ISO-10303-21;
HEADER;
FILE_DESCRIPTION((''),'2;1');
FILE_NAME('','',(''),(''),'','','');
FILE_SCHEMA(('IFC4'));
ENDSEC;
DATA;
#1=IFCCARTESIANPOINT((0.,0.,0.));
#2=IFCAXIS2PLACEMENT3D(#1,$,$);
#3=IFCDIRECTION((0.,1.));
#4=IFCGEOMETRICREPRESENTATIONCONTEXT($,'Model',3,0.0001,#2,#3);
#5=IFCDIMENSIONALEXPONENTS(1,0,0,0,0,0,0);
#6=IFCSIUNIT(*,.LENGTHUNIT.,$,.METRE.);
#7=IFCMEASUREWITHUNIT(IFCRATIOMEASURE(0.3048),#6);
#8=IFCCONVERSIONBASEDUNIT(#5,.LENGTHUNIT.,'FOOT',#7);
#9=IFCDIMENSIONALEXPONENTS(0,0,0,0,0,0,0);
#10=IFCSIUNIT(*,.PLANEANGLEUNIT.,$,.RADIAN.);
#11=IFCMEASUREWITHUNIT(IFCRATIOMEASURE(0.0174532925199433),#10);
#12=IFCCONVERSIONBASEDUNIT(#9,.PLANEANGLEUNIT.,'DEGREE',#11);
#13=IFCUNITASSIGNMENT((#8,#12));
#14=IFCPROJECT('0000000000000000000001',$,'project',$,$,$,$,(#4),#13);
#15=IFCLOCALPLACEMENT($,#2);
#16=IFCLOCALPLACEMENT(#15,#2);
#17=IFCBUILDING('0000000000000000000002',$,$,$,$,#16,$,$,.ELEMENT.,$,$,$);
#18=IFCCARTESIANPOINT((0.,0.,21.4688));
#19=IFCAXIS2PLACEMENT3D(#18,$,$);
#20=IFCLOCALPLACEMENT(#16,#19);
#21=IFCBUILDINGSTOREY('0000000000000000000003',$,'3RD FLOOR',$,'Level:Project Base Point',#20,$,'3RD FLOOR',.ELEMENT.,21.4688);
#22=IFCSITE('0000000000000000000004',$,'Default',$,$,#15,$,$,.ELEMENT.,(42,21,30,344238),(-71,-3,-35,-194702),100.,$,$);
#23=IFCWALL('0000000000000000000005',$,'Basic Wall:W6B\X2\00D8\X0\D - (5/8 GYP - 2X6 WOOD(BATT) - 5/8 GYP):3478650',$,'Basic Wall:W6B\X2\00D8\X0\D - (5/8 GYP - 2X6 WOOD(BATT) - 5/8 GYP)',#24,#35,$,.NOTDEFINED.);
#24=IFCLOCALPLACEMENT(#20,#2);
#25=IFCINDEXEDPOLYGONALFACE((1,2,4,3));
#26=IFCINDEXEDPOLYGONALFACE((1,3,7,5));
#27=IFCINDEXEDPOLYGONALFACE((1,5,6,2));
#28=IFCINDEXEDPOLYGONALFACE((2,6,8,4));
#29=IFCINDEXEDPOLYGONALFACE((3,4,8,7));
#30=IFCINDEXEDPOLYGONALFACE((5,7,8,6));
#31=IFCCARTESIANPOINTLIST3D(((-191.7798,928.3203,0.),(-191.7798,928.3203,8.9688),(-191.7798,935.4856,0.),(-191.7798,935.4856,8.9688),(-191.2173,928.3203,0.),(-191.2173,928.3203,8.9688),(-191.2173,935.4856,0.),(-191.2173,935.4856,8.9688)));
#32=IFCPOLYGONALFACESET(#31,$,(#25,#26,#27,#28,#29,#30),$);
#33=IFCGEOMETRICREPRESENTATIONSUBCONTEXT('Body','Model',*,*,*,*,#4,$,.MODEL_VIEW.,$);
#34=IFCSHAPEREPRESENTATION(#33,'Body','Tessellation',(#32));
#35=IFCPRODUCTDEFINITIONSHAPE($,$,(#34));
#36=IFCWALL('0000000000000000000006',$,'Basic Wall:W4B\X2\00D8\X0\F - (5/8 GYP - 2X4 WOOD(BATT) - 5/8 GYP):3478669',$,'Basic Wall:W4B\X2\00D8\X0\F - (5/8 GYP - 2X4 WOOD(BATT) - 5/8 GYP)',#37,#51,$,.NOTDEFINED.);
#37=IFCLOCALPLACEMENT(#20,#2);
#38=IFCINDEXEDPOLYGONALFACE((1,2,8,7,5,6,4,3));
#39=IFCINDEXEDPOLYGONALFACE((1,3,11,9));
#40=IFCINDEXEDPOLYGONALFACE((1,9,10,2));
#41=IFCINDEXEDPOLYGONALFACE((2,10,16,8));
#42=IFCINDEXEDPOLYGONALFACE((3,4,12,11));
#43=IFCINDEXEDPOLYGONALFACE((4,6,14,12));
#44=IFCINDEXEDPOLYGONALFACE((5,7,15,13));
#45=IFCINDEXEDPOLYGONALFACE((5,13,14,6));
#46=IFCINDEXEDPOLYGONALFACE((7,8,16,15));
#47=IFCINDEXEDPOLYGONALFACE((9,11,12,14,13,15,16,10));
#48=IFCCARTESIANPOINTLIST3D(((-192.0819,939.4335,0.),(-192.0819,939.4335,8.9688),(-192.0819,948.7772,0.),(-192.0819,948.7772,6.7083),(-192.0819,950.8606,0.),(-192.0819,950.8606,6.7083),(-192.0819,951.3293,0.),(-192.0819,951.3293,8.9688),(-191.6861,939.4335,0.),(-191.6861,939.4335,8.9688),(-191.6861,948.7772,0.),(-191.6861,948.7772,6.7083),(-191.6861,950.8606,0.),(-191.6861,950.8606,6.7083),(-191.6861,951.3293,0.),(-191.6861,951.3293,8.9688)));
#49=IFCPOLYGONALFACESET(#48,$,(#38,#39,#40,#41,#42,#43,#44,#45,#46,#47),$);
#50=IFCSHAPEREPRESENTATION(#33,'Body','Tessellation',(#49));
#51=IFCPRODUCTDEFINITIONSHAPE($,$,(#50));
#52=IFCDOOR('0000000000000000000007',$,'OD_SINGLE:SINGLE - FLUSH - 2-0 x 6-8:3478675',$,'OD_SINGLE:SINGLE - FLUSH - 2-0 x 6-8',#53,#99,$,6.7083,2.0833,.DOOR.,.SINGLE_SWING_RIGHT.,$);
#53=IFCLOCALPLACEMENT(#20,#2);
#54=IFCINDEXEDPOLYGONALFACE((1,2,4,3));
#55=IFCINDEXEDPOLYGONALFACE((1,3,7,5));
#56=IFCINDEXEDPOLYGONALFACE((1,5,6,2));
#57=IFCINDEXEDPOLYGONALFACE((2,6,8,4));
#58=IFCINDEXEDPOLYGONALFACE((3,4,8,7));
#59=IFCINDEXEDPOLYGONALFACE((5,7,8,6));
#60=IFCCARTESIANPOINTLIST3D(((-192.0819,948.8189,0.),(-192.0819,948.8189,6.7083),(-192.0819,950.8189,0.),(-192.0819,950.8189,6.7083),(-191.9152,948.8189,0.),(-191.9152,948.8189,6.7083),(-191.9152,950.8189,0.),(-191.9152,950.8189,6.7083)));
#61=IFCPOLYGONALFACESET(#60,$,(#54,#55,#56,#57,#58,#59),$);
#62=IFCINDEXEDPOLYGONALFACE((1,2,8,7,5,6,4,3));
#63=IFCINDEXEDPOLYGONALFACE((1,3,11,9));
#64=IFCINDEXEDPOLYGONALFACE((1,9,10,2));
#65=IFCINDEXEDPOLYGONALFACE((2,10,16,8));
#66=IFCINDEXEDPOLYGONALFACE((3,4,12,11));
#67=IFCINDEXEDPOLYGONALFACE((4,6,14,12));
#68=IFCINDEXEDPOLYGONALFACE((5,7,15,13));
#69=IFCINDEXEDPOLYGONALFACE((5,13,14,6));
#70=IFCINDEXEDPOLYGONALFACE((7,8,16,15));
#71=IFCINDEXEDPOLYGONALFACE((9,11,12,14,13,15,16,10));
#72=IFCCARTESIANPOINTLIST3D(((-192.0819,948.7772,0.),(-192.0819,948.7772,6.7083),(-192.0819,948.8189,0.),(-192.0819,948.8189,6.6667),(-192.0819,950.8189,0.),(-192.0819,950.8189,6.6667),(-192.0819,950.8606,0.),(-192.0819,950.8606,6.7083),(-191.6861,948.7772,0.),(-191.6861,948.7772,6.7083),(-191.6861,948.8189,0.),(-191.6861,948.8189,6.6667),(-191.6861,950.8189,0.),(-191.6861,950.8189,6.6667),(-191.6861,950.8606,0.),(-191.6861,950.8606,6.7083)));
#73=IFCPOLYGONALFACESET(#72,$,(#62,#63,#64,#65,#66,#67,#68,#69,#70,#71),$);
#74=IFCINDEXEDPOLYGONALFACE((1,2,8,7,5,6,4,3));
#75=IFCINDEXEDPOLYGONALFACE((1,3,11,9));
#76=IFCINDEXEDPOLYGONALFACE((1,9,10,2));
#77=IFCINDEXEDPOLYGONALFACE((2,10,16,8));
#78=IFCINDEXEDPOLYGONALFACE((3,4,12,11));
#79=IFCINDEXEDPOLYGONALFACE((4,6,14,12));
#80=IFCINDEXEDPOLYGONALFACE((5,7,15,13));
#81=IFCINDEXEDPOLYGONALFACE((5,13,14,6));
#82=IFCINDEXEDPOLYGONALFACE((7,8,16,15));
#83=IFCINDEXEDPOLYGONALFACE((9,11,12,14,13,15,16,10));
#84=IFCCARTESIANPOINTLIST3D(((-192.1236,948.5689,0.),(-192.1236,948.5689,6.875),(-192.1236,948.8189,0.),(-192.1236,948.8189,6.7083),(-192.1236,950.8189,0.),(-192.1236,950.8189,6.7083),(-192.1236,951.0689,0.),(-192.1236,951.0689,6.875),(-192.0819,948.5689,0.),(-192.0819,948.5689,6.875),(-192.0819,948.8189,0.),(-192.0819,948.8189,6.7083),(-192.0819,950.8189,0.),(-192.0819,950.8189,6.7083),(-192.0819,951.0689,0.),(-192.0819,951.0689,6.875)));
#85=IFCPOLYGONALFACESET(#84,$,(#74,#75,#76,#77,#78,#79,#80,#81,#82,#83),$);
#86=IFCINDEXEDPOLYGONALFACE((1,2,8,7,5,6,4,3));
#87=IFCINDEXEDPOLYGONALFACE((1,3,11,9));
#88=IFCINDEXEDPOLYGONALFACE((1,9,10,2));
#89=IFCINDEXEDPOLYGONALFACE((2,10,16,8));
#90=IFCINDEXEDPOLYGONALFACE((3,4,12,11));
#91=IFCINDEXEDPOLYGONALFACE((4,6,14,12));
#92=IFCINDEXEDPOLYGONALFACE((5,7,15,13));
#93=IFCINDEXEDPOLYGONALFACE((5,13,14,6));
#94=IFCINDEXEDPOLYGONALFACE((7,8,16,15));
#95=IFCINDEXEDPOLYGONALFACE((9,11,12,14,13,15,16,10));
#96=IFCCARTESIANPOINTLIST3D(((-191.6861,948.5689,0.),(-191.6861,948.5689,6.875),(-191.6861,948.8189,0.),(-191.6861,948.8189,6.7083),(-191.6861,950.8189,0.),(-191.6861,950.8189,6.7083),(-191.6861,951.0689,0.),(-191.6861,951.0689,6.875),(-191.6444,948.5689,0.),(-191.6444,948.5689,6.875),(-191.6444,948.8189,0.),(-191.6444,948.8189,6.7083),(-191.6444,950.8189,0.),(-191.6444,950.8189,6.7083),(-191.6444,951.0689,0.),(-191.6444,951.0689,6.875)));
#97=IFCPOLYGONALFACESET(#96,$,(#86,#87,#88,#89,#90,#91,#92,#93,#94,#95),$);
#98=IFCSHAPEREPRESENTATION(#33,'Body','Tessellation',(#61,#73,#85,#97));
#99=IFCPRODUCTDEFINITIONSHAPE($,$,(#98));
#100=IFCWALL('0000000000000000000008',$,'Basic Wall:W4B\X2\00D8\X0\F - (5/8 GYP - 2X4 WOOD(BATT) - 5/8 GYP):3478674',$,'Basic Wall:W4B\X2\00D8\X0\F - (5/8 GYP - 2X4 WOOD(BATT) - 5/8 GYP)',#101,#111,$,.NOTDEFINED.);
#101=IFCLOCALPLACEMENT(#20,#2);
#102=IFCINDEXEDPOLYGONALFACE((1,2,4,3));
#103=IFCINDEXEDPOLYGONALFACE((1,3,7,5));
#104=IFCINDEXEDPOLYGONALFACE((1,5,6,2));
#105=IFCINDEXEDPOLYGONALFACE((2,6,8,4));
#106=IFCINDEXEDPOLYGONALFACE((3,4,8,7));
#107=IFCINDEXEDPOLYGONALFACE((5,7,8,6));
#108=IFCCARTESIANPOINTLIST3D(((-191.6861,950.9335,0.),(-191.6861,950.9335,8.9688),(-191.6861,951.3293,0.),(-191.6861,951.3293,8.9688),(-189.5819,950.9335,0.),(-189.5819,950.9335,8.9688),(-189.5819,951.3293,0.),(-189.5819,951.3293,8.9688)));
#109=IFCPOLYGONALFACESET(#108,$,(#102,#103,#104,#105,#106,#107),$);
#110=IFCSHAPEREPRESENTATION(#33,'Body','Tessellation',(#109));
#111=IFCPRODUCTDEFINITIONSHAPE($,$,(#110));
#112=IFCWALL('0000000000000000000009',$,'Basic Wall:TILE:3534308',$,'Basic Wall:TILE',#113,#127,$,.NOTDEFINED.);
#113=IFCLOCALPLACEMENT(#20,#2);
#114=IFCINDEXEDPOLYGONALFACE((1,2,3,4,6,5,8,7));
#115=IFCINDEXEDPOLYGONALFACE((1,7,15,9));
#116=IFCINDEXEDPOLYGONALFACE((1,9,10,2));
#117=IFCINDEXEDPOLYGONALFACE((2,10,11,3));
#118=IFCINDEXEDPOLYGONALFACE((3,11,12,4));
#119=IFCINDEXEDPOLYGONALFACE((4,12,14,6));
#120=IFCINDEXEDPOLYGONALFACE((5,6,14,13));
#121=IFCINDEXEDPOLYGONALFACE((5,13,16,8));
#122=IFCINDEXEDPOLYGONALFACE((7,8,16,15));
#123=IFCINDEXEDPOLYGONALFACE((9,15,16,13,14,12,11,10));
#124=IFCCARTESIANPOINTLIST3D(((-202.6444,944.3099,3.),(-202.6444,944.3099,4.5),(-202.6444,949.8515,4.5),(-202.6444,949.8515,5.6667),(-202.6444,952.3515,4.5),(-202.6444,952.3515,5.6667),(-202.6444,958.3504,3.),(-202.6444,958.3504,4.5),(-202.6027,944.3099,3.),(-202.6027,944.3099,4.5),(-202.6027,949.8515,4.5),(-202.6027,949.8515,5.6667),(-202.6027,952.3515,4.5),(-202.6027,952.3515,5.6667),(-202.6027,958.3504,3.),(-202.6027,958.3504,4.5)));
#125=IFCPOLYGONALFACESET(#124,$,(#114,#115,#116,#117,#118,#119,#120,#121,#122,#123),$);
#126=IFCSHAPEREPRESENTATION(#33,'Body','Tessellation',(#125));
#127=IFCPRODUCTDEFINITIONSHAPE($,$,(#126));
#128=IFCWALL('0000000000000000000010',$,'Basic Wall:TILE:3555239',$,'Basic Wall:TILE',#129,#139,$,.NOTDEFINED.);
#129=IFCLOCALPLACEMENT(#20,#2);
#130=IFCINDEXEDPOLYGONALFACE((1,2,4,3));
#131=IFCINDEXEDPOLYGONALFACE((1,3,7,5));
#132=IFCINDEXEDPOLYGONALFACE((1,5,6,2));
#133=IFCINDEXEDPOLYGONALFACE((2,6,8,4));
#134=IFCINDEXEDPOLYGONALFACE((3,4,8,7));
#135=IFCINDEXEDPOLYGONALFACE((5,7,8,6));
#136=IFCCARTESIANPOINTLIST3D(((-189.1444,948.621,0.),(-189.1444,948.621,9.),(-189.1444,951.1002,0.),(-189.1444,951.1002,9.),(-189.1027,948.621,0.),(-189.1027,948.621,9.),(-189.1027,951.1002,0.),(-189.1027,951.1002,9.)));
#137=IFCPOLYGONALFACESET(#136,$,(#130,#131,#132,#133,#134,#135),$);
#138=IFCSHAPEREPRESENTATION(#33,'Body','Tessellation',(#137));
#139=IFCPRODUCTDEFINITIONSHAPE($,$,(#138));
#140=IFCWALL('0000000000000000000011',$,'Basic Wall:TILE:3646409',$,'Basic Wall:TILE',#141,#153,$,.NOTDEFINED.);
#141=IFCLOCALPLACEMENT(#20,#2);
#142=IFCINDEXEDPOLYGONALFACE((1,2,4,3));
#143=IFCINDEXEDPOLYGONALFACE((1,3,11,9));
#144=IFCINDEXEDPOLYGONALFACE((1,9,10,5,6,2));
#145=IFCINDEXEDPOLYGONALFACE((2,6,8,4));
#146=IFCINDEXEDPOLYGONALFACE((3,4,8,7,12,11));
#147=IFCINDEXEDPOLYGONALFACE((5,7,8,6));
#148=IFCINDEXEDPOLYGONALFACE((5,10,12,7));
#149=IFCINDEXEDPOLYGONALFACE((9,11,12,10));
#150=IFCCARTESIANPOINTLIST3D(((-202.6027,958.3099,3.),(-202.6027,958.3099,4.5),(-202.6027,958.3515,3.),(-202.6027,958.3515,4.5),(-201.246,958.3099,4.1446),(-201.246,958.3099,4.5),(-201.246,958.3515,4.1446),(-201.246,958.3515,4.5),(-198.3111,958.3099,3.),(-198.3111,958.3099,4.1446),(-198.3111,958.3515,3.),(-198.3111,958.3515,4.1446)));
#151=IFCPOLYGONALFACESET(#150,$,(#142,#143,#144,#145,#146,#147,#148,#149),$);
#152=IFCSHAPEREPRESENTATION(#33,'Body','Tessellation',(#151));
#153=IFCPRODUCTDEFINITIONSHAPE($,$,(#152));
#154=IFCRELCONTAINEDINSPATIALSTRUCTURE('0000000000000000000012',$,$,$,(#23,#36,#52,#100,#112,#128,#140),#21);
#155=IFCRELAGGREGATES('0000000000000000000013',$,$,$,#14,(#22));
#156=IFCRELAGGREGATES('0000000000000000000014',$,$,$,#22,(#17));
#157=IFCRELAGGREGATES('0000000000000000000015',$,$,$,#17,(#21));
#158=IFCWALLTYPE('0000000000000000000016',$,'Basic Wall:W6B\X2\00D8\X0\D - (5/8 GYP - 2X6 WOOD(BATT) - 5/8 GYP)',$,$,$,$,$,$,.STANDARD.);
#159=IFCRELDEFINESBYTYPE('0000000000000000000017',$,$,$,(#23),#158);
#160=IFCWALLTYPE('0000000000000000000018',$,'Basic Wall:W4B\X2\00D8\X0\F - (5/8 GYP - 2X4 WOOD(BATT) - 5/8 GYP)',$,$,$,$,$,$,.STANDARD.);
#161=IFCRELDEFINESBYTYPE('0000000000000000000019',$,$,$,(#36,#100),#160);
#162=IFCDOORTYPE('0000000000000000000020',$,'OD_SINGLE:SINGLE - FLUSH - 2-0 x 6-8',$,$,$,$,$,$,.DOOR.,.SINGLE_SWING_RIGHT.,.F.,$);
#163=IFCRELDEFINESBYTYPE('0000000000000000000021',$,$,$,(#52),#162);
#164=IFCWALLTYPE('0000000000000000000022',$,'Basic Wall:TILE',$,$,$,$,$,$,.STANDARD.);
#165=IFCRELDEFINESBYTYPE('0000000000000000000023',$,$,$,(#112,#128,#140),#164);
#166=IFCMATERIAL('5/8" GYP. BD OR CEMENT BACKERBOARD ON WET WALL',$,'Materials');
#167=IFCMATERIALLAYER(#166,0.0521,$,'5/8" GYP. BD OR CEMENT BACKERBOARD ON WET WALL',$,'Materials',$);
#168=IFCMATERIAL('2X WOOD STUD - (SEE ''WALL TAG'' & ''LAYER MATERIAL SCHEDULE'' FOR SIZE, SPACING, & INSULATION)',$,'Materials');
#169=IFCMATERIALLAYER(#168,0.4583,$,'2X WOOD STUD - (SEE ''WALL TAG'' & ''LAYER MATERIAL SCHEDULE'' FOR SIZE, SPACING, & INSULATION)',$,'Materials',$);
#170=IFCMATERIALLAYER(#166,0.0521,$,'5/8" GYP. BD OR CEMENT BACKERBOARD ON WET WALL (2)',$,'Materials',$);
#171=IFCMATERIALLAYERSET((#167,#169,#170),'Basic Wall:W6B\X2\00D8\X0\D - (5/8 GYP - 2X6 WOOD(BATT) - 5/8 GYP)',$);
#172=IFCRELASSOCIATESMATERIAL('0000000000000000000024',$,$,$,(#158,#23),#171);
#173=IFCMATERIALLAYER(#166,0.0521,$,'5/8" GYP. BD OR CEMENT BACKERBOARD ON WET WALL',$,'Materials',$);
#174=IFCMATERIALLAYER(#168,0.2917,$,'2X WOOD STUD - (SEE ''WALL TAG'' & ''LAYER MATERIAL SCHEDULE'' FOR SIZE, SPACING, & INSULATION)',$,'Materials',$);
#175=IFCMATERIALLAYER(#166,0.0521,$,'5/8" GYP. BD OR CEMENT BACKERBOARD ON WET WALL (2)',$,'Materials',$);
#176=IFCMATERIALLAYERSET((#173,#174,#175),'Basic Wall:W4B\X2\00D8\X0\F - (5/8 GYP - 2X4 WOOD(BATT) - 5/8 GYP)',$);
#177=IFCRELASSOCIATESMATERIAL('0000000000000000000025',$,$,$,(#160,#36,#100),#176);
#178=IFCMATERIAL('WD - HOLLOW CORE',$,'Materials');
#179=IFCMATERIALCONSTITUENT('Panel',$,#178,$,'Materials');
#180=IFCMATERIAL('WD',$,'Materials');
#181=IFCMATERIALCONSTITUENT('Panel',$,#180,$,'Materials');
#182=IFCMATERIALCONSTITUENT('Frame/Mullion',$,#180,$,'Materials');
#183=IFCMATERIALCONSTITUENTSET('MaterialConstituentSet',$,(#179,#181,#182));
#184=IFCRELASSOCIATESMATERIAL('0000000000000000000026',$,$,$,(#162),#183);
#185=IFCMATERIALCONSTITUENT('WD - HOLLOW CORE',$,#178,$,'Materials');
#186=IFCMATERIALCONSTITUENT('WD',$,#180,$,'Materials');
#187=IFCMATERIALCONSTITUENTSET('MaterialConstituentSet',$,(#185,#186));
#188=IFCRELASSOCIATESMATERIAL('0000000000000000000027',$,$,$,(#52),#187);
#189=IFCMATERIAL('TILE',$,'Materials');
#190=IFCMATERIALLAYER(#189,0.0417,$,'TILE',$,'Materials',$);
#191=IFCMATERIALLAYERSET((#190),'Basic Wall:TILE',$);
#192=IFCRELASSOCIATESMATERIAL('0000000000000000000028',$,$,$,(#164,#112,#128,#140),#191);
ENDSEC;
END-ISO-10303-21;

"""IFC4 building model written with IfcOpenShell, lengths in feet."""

from ifc_helpers import new_model, entity, si_unit, converted_unit, direction, frame, frame_2d, origin, origin_2d_with_axis, place, context, subcontext, project, spatial, polyline, rectangle, outline, extrude, source, transform, mapped, material, layer, layer_set, layer_usage, constituent, constituent_set, type_object, type_shapes, element, fill, save


model = new_model("IFC4")

# Units and contexts
model_context = context("Model", 3, precision=0.0001, world=origin(), true_north=direction((0.0, 1.0)))
body_context = subcontext(model_context, "Body", "Model", "MODEL_VIEW")
ifc_project = project(units=[converted_unit("LENGTHUNIT", "FOOT", entity("IfcRatioMeasure", 0.3048), si_unit("LENGTHUNIT", "METRE"), dimensions=[1, 0, 0, 0, 0, 0, 0]), converted_unit("PLANEANGLEUNIT", "DEGREE", entity("IfcRatioMeasure", 0.0174532925199433), si_unit("PLANEANGLEUNIT", "RADIAN"), dimensions=[0, 0, 0, 0, 0, 0, 0])], contexts=[model_context])

# Site, building, storey
site_placement = place(None, origin())
site = spatial("IfcSite", under=ifc_project, at=site_placement, Name="Default", CompositionType="ELEMENT", RefLatitude=(42, 21, 30, 344238), RefLongitude=(-71, -3, -35, -194702), RefElevation=100.0)
building_placement = place(site_placement, origin())
building = spatial("IfcBuilding", under=site, at=building_placement, CompositionType="ELEMENT")
storey_placement = place(building_placement, frame((0.0, 0.0, 21.4688)))
storey = spatial("IfcBuildingStorey", under=building, at=storey_placement, Name="3RD FLOOR", ObjectType="Level:Project Base Point", LongName="3RD FLOOR", CompositionType="ELEMENT", Elevation=21.4688)

# Wall
ifc_material_1 = material(Name="5/8\" GYP. BD OR CEMENT BACKERBOARD ON WET WALL", Category="Materials")
ifc_layer_1 = layer(ifc_material_1, 0.0521, Name="5/8\" GYP. BD OR CEMENT BACKERBOARD ON WET WALL", Category="Materials")
ifc_material_2 = material(Name="2X WOOD STUD - (SEE 'WALL TAG' & 'LAYER MATERIAL SCHEDULE' FOR SIZE, SPACING, & INSULATION)", Category="Materials")
ifc_layer_2 = layer(ifc_material_2, 0.4583, Name="2X WOOD STUD - (SEE 'WALL TAG' & 'LAYER MATERIAL SCHEDULE' FOR SIZE, SPACING, & INSULATION)", Category="Materials")
ifc_layer_3 = layer(ifc_material_1, 0.0521, Name="5/8\" GYP. BD OR CEMENT BACKERBOARD ON WET WALL (2)", Category="Materials")
ifc_layer_set_1 = layer_set([ifc_layer_1, ifc_layer_2, ifc_layer_3], Name="Basic Wall:W6BØD - (5/8 GYP - 2X6 WOOD(BATT) - 5/8 GYP)")
ifc_layer_usage_1 = layer_usage(ifc_layer_set_1, "AXIS2", "NEGATIVE", 0.2812)
wall_type_1 = type_object("IfcWallType", Name="Basic Wall:W6BØD - (5/8 GYP - 2X6 WOOD(BATT) - 5/8 GYP)", PredefinedType="STANDARD", material=ifc_layer_set_1)
wall_1_placement = place(storey_placement, frame((-191.4985, 928.3203, 0.0), z_axis=(0.0, 0.0, 1.0), x_axis=(0.0, 1.0, 0.0)))
element("IfcWall", 1, at=wall_1_placement, inside=storey, type_object=wall_type_1, material=ifc_layer_usage_1, Name="Basic Wall:W6BØD - (5/8 GYP - 2X6 WOOD(BATT) - 5/8 GYP):3478650", ObjectType="Basic Wall:W6BØD - (5/8 GYP - 2X6 WOOD(BATT) - 5/8 GYP)", PredefinedType="NOTDEFINED", context=body_context, shape_type="SweptSolid", body=[
    extrude(rectangle(XDim=7.1653, YDim=0.5625, at=frame_2d((3.5826, 0.0), x_axis=(-1.0, 0.0))), origin(), (0.0, 0.0, 1.0), 8.9688),
])

# Wall, opening, door
ifc_layer_4 = layer(ifc_material_1, 0.0521, Name="5/8\" GYP. BD OR CEMENT BACKERBOARD ON WET WALL", Category="Materials")
ifc_layer_5 = layer(ifc_material_2, 0.2917, Name="2X WOOD STUD - (SEE 'WALL TAG' & 'LAYER MATERIAL SCHEDULE' FOR SIZE, SPACING, & INSULATION)", Category="Materials")
ifc_layer_6 = layer(ifc_material_1, 0.0521, Name="5/8\" GYP. BD OR CEMENT BACKERBOARD ON WET WALL (2)", Category="Materials")
ifc_layer_set_2 = layer_set([ifc_layer_4, ifc_layer_5, ifc_layer_6], Name="Basic Wall:W4BØF - (5/8 GYP - 2X4 WOOD(BATT) - 5/8 GYP)")
wall_type_2 = type_object("IfcWallType", Name="Basic Wall:W4BØF - (5/8 GYP - 2X4 WOOD(BATT) - 5/8 GYP)", PredefinedType="STANDARD", material=ifc_layer_set_2)
ifc_material_3 = material(Name="WD - HOLLOW CORE", Category="Materials")
ifc_material_4 = material(Name="WD", Category="Materials")
ifc_layer_usage_2 = layer_usage(ifc_layer_set_2, "AXIS2", "NEGATIVE", 0.1979)
wall_2_placement = place(storey_placement, frame((-191.884, 939.4335, 0.0), z_axis=(0.0, 0.0, 1.0), x_axis=(0.0, 1.0, 0.0)))
wall_2 = element("IfcWall", 2, at=wall_2_placement, inside=storey, type_object=wall_type_2, material=ifc_layer_usage_2, Name="Basic Wall:W4BØF - (5/8 GYP - 2X4 WOOD(BATT) - 5/8 GYP):3478669", ObjectType="Basic Wall:W4BØF - (5/8 GYP - 2X4 WOOD(BATT) - 5/8 GYP)", PredefinedType="NOTDEFINED", context=body_context, shape_type="SweptSolid", body=[
    extrude(rectangle(XDim=11.8958, YDim=0.3958, at=frame_2d((5.9479, 0.0), x_axis=(-1.0, 0.0))), origin(), (0.0, 0.0, 1.0), 8.9688),
])
opening_1_placement = place(wall_2_placement, frame((9.3438, -0.1979, 0.0)))
opening_1 = element("IfcOpeningElement", 3, at=opening_1_placement, cuts=wall_2, PredefinedType="OPENING", context=body_context, shape_type="SweptSolid", body=[
    extrude(rectangle(XDim=2.0833, YDim=6.7083, at=frame_2d((3.3542, 1.0417), x_axis=(0.0, 1.0))), frame((0.0, 0.0, 0.0), z_axis=(0.0, 1.0, 0.0), x_axis=(0.0, 0.0, 1.0)), (0.0, 0.0, 1.0), 0.3958),
])
ifc_constituent_1 = constituent(ifc_material_3, Name="WD - HOLLOW CORE", Category="Materials")
ifc_constituent_2 = constituent(ifc_material_4, Name="WD", Category="Materials")
ifc_constituent_set_1 = constituent_set(constituents=[ifc_constituent_1, ifc_constituent_2], Name="MaterialConstituentSet")
ifc_constituent_3 = constituent(ifc_material_3, Name="Panel", Category="Materials")
ifc_constituent_4 = constituent(ifc_material_4, Name="Panel", Category="Materials")
ifc_constituent_5 = constituent(ifc_material_4, Name="Frame/Mullion", Category="Materials")
ifc_constituent_set_2 = constituent_set(constituents=[ifc_constituent_3, ifc_constituent_4, ifc_constituent_5], Name="MaterialConstituentSet")
door_type_1 = type_object("IfcDoorType", Name="OD_SINGLE:SINGLE - FLUSH - 2-0 x 6-8", OperationType="SINGLE_SWING_RIGHT", ParameterTakesPrecedence=False, PredefinedType="DOOR", material=ifc_constituent_set_2)
shared_shape_1 = source(origin(), body_context, "Body", "SweptSolid", [
    extrude(rectangle(XDim=0.1667, YDim=2.0, at=origin_2d_with_axis()), frame((1.0417, 0.3125, 0.0), z_axis=(0.0, 0.0, 1.0), x_axis=(0.0, 1.0, 0.0)), (0.0, 0.0, 1.0), 6.7083),
    extrude(outline(polyline([(-3.3646, -1.0417), (3.3438, -1.0417), (3.3438, -1.0), (-3.3229, -1.0), (-3.3229, 1.0), (3.3438, 1.0), (3.3438, 1.0417), (-3.3646, 1.0417), (-3.3646, -1.0417)])), frame((1.0417, 0.0, 3.3438), z_axis=(0.0, 1.0, 0.0), x_axis=(0.0, 0.0, -1.0)), (0.0, 0.0, 1.0), 0.3958),
    extrude(outline(polyline([(-1.25, -3.4792), (1.25, -3.4792), (1.25, 3.3958), (1.0, 3.3958), (1.0, -3.3125), (-1.0, -3.3125), (-1.0, 3.3958), (-1.25, 3.3958), (-1.25, -3.4792)])), frame((1.0417, 0.3958, 3.3958), z_axis=(0.0, 1.0, 0.0), x_axis=(1.0, 0.0, 0.0)), (0.0, 0.0, 1.0), 0.0417),
    extrude(outline(polyline([(-3.4792, -1.25), (3.3958, -1.25), (3.3958, -1.0), (-3.3125, -1.0), (-3.3125, 1.0), (3.3958, 1.0), (3.3958, 1.25), (-3.4792, 1.25), (-3.4792, -1.25)])), frame((1.0417, -0.0417, 3.3958), z_axis=(0.0, 1.0, 0.0), x_axis=(0.0, 0.0, -1.0)), (0.0, 0.0, 1.0), 0.0417),
])
type_shapes(door_type_1, [shared_shape_1])
door_1_placement = place(opening_1_placement, origin())
door_1 = element("IfcDoor", 4, at=door_1_placement, inside=storey, type_object=door_type_1, material=ifc_constituent_set_1, Name="OD_SINGLE:SINGLE - FLUSH - 2-0 x 6-8:3478675", ObjectType="OD_SINGLE:SINGLE - FLUSH - 2-0 x 6-8", OperationType="SINGLE_SWING_RIGHT", OverallHeight=6.7083, OverallWidth=2.0833, PredefinedType="DOOR", context=body_context, shape_type="MappedRepresentation", body=[
    mapped(shared_shape_1, transform((0.0, 0.0, 0.0), scale=1.0)),
])
fill(opening_1, door_1)

# Wall
ifc_layer_usage_3 = layer_usage(ifc_layer_set_2, "AXIS2", "POSITIVE", -0.1979)
wall_3_placement = place(storey_placement, frame((-189.5819, 951.1314, 0.0), z_axis=(0.0, 0.0, 1.0), x_axis=(-1.0, 0.0, 0.0)))
element("IfcWall", 5, at=wall_3_placement, inside=storey, type_object=wall_type_2, material=ifc_layer_usage_3, Name="Basic Wall:W4BØF - (5/8 GYP - 2X4 WOOD(BATT) - 5/8 GYP):3478674", ObjectType="Basic Wall:W4BØF - (5/8 GYP - 2X4 WOOD(BATT) - 5/8 GYP)", PredefinedType="NOTDEFINED", context=body_context, shape_type="SweptSolid", body=[
    extrude(rectangle(XDim=2.1042, YDim=0.3958, at=frame_2d((1.0521, 0.0), x_axis=(-1.0, 0.0))), origin(), (0.0, 0.0, 1.0), 8.9688),
])

# Wall, openings
ifc_material_5 = material(Name="TILE", Category="Materials")
ifc_layer_7 = layer(ifc_material_5, 0.0417, Name="TILE", Category="Materials")
ifc_layer_set_3 = layer_set([ifc_layer_7], Name="Basic Wall:TILE")
ifc_layer_usage_4 = layer_usage(ifc_layer_set_3, "AXIS2", "POSITIVE", -0.0208)
wall_type_3 = type_object("IfcWallType", Name="Basic Wall:TILE", PredefinedType="STANDARD", material=ifc_layer_set_3)
wall_4_placement = place(storey_placement, frame((-202.6236, 958.3504, 3.0), z_axis=(0.0, 0.0, 1.0), x_axis=(0.0, -1.0, 0.0)))
wall_4 = element("IfcWall", 6, at=wall_4_placement, inside=storey, type_object=wall_type_3, material=ifc_layer_usage_4, Name="Basic Wall:TILE:3534308", ObjectType="Basic Wall:TILE", PredefinedType="NOTDEFINED", context=body_context, shape_type="SweptSolid", body=[
    extrude(rectangle(XDim=14.0406, YDim=0.0417, at=frame_2d((7.0203, 0.0), x_axis=(-1.0, 0.0))), origin(), (0.0, 0.0, 1.0), 2.6667),
])
opening_2_placement = place(wall_4_placement, origin())
element("IfcOpeningElement", 7, at=opening_2_placement, cuts=wall_4, PredefinedType="OPENING", context=body_context, shape_type="SweptSolid", body=[
    extrude(rectangle(XDim=1.1667, YDim=5.5417, at=origin_2d_with_axis()), frame((11.2697, 0.0208, 2.0833), z_axis=(0.0, -1.0, 0.0), x_axis=(0.0, 0.0, 1.0)), (0.0, 0.0, 1.0), 0.0417),
])
opening_3_placement = place(wall_4_placement, origin())
element("IfcOpeningElement", 8, at=opening_3_placement, cuts=wall_4, PredefinedType="OPENING", context=body_context, shape_type="SweptSolid", body=[
    extrude(rectangle(XDim=1.1667, YDim=5.9989, at=frame_2d((0.0, 0.0), x_axis=(0.0, 1.0))), frame((2.9994, 0.0208, 2.0833), z_axis=(0.0, -1.0, 0.0), x_axis=(-1.0, 0.0, 0.0)), (0.0, 0.0, 1.0), 0.0417),
])

# Wall
ifc_layer_usage_5 = layer_usage(ifc_layer_set_3, "AXIS2", "POSITIVE", -0.0208)
wall_5_placement = place(storey_placement, frame((-189.1236, 951.1002, 0.0), z_axis=(0.0, 0.0, 1.0), x_axis=(0.0, -1.0, 0.0)))
element("IfcWall", 9, at=wall_5_placement, inside=storey, type_object=wall_type_3, material=ifc_layer_usage_5, Name="Basic Wall:TILE:3555239", ObjectType="Basic Wall:TILE", PredefinedType="NOTDEFINED", context=body_context, shape_type="SweptSolid", body=[
    extrude(rectangle(XDim=2.4792, YDim=0.0417, at=frame_2d((1.2396, 0.0), x_axis=(-1.0, 0.0))), origin(), (0.0, 0.0, 1.0), 9.0),
])

# Wall, opening
ifc_layer_usage_6 = layer_usage(ifc_layer_set_3, "AXIS2", "NEGATIVE", 0.0208)
wall_6_placement = place(storey_placement, frame((-202.6027, 958.3307, 3.0)))
wall_6 = element("IfcWall", 10, at=wall_6_placement, inside=storey, type_object=wall_type_3, material=ifc_layer_usage_6, Name="Basic Wall:TILE:3646409", ObjectType="Basic Wall:TILE", PredefinedType="NOTDEFINED", context=body_context, shape_type="SweptSolid", body=[
    extrude(rectangle(XDim=4.2917, YDim=0.0417, at=frame_2d((2.1458, 0.0), x_axis=(-1.0, 0.0))), origin(), (0.0, 0.0, 1.0), 1.5),
])
opening_4_placement = place(wall_6_placement, origin())
element("IfcOpeningElement", 11, at=opening_4_placement, cuts=wall_6, PredefinedType="OPENING", context=body_context, shape_type="SweptSolid", body=[
    extrude(rectangle(XDim=0.3554, YDim=2.9349, at=frame_2d((0.0, 0.0), x_axis=(1.0, 0.0))), frame((2.8242, 0.0208, 1.3223), z_axis=(0.0, -1.0, 0.0), x_axis=(0.0, 0.0, 1.0)), (0.0, 0.0, 1.0), 0.0417),
])

save(model, "model.ifc")
